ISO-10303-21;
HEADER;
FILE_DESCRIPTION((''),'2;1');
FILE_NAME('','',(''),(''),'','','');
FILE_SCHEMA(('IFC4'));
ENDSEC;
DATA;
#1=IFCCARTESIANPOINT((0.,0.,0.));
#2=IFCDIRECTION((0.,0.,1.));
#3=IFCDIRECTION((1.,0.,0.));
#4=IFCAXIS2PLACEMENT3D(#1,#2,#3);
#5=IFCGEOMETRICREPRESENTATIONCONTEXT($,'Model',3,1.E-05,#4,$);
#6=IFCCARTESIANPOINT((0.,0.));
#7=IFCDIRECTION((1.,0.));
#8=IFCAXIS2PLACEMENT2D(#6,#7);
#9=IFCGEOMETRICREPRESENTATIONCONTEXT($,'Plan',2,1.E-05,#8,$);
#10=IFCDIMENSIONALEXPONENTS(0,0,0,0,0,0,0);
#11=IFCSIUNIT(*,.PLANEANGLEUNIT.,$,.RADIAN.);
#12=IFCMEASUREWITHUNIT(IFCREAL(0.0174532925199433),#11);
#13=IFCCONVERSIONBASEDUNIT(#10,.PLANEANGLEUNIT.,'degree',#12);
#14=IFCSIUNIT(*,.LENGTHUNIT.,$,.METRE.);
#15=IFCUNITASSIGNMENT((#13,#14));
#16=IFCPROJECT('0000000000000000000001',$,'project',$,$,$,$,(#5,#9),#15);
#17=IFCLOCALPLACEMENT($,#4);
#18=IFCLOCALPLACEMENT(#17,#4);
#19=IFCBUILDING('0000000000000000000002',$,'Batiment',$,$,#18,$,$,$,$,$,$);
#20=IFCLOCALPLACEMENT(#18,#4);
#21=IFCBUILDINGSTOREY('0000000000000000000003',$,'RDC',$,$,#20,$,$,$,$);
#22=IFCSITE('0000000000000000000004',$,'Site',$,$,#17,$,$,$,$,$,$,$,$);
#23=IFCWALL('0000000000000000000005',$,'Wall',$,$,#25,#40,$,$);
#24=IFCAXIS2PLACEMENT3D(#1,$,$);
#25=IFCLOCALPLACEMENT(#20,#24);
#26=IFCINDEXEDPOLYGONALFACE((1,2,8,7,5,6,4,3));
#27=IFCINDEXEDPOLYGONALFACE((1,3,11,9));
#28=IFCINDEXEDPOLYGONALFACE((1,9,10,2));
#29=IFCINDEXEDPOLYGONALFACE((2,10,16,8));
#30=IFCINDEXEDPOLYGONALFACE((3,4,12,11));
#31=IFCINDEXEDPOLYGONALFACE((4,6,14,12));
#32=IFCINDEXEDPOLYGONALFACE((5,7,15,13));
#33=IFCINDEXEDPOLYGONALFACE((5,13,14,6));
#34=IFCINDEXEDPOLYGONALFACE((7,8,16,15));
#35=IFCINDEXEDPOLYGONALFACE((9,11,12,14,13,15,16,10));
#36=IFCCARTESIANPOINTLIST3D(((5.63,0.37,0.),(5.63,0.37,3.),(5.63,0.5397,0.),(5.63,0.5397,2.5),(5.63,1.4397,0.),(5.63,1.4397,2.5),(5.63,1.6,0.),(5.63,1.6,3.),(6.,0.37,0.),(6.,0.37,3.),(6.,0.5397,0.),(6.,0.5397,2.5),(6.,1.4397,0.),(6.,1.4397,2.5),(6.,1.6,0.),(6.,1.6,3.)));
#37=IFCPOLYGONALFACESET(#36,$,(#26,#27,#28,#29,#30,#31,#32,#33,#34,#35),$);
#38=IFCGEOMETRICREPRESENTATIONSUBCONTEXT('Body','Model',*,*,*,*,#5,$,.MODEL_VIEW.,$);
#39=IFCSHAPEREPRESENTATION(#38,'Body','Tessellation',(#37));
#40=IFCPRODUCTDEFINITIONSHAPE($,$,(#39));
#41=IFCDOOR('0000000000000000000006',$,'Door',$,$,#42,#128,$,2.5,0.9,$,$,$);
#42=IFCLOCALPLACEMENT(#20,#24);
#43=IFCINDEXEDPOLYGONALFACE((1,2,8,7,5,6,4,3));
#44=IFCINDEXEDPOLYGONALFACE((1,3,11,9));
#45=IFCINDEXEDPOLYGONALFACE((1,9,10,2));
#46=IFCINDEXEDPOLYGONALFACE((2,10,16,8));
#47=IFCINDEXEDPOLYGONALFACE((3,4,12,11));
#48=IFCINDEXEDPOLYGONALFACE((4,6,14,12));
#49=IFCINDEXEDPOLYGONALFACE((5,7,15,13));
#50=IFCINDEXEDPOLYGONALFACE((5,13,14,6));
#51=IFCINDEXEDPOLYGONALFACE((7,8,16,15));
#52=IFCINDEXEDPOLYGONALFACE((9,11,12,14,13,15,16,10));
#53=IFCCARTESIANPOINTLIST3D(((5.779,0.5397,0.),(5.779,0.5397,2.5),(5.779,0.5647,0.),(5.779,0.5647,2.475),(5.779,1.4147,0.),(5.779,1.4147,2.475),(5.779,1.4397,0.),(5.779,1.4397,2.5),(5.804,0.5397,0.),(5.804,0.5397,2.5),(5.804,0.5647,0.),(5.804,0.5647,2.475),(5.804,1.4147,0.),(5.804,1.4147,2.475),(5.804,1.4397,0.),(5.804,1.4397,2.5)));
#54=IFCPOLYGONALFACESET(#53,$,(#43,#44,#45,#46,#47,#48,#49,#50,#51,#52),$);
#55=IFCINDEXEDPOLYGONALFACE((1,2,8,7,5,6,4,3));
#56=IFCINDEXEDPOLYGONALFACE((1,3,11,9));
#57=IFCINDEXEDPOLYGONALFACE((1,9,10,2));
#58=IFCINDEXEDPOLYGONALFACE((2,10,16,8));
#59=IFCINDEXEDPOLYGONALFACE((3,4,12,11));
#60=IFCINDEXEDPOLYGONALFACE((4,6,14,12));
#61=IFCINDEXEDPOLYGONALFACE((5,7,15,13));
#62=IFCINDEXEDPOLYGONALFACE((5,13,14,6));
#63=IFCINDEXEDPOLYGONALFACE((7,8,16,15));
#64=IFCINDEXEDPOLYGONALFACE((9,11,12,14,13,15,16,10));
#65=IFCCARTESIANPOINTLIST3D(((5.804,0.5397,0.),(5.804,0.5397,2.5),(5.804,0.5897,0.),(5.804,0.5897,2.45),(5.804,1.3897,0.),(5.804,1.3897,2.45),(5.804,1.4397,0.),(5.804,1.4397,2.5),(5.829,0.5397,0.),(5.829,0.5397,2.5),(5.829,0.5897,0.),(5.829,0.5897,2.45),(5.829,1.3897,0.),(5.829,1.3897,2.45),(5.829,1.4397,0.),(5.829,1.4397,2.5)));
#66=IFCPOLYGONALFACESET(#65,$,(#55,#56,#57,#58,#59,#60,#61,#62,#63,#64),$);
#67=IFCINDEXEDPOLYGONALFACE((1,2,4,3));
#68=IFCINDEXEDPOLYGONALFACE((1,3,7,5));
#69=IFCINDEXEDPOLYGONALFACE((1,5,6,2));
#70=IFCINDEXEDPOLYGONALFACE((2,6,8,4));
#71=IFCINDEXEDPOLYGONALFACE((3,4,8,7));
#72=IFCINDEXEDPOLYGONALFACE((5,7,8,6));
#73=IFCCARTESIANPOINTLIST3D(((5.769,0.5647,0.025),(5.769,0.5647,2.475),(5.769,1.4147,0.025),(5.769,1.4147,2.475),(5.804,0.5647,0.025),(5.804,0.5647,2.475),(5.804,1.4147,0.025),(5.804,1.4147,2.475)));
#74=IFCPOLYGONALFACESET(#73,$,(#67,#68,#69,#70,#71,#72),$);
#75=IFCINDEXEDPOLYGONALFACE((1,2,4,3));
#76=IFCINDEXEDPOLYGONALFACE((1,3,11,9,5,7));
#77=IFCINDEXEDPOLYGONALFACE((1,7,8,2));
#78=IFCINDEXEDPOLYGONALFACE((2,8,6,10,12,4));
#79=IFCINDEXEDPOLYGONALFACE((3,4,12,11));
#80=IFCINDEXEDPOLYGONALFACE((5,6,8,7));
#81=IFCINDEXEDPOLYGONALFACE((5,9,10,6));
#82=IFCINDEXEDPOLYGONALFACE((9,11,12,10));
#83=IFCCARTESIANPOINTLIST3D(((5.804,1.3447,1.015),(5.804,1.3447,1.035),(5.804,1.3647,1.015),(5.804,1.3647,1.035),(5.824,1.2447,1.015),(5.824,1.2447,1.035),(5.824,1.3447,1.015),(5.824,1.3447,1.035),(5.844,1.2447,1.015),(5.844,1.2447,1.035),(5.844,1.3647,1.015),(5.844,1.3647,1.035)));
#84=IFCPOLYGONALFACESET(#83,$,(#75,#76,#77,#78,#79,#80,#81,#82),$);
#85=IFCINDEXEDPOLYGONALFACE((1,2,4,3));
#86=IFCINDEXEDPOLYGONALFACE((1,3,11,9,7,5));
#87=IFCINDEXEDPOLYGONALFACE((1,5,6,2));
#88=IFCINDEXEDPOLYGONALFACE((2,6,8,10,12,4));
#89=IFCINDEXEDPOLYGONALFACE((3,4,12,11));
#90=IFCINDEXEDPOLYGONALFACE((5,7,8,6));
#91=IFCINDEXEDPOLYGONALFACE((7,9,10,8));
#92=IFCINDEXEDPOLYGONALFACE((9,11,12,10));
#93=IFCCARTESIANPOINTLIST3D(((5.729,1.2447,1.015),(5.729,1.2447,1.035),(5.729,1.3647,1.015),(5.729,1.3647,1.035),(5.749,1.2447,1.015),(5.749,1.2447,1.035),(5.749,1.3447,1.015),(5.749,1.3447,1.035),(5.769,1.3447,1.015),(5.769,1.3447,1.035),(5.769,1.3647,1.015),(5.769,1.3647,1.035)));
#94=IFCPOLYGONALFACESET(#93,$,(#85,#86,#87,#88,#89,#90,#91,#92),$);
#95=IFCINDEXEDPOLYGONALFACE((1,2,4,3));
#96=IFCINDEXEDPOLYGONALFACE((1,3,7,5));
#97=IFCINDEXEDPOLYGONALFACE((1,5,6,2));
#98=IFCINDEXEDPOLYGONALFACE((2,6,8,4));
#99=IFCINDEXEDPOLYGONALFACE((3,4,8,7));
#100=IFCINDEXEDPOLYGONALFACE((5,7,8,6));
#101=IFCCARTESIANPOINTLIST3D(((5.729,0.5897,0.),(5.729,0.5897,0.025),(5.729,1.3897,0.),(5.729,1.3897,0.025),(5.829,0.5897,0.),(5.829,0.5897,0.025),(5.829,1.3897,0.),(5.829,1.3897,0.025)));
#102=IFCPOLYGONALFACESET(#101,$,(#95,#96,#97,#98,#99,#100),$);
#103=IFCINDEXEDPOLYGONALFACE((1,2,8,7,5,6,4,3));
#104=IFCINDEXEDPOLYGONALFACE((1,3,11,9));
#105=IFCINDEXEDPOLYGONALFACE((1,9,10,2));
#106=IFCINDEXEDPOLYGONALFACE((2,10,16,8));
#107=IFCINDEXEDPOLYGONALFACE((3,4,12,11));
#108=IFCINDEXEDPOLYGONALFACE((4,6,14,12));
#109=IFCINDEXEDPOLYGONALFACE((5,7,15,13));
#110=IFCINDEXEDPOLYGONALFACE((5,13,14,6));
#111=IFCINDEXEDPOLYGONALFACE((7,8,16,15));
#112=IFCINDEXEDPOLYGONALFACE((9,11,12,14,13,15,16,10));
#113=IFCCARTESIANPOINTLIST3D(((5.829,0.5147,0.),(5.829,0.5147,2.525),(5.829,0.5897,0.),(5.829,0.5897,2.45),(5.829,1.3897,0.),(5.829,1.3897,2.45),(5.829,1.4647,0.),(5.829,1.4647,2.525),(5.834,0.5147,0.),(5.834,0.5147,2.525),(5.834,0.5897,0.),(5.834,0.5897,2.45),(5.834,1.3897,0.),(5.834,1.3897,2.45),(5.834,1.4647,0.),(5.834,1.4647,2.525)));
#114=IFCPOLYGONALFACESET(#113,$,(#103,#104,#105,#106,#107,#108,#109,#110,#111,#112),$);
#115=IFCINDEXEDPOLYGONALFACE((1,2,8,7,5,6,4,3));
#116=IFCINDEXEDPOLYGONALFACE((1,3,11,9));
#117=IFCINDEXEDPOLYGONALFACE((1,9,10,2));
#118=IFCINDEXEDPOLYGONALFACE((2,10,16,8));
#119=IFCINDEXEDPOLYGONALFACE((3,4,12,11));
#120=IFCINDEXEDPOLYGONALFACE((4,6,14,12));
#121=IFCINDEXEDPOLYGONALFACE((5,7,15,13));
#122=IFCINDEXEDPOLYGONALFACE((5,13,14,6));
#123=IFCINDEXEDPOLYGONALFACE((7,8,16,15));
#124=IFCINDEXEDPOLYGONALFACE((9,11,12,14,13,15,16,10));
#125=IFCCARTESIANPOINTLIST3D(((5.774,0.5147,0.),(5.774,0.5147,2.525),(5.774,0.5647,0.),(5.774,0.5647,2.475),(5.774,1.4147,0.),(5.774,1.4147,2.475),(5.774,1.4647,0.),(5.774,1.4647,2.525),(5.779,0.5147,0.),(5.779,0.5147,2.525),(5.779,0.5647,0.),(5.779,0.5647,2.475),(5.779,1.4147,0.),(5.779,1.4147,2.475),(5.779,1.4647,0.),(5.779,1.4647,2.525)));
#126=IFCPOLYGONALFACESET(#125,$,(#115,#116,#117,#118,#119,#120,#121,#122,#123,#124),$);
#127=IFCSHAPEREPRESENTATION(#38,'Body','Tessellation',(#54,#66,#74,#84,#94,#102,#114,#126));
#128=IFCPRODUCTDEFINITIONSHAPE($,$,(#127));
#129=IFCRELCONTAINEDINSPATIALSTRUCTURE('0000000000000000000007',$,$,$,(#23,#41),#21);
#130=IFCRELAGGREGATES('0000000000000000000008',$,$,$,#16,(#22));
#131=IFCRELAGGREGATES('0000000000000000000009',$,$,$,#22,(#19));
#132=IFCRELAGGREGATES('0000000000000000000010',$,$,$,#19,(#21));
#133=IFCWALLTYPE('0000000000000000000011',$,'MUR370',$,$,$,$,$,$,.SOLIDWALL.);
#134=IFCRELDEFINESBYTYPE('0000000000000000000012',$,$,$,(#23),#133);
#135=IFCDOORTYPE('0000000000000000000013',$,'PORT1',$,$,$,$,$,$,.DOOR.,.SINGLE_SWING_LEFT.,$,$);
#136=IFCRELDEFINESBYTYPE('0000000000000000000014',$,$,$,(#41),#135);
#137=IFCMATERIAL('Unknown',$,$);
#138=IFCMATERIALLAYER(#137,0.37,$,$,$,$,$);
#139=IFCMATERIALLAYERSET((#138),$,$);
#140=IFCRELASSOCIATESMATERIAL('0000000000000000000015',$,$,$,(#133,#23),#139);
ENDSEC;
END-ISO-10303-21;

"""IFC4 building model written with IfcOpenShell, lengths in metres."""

from ifc_helpers import new_model, entity, si_unit, converted_unit, frame, origin_with_axes, origin_2d_with_axis, place, context, subcontext, project, spatial, line, indexed_curve, outline, extrude, shape, source, transform, mapped, material, layer, layer_set, layer_usage, type_object, type_shapes, element, fill, save


model = new_model("IFC4")

# Units and contexts
model_context = context("Model", 3, precision=1e-05, world=origin_with_axes())
plan_context = context("Plan", 2, precision=1e-05, world=origin_2d_with_axis())
body_context_1 = subcontext(model_context, "Body", "Model", "MODEL_VIEW")
body_context_2 = subcontext(plan_context, "Body", "Plan", "PLAN_VIEW")
ifc_project = project(units=[converted_unit("PLANEANGLEUNIT", "degree", entity("IfcReal", 0.0174532925199433), si_unit("PLANEANGLEUNIT", "RADIAN"), dimensions=[0, 0, 0, 0, 0, 0, 0]), si_unit("LENGTHUNIT", "METRE")], contexts=[model_context, plan_context])

# Site, building, storey
site_placement = place(None, origin_with_axes())
site = spatial("IfcSite", under=ifc_project, at=site_placement, Name="Site")
building_placement = place(site_placement, origin_with_axes())
building = spatial("IfcBuilding", under=site, at=building_placement, Name="Batiment")
storey_placement = place(building_placement, origin_with_axes())
storey = spatial("IfcBuildingStorey", under=building, at=storey_placement, Name="RDC")

# Shared definitions
ifc_material = material(Name="Unknown")

# Shared definitions
ifc_layer_1 = layer(ifc_material, 0.37)
ifc_layer_set_1 = layer_set([ifc_layer_1])
wall_type_1 = type_object("IfcWallType", Name="MUR370", PredefinedType="SOLIDWALL", material=ifc_layer_set_1)

# Wall, opening, door
ifc_layer_usage_1 = layer_usage(ifc_layer_set_1, "AXIS2", "POSITIVE", 0.0)
wall_1_placement = place(storey_placement, frame((6.0, 0.37, 0.0), z_axis=(0.0, 0.0, 1.0), x_axis=(0.0, 1.0, 0.0)))
wall_1 = element("IfcWall", 1, at=wall_1_placement, inside=storey, type_object=wall_type_1, material=ifc_layer_usage_1, Name="Wall", context=body_context_1, shape_type="SweptSolid", body=[
    extrude(outline(indexed_curve([(0.0, 0.0), (0.0, 0.37), (1.23, 0.37), (1.23, 0.0), (0.0, 0.0)], self_intersect=False)), origin_with_axes(), (0.0, 0.0, 1.0), 3.0),
])
shared_shape_1 = source(origin_with_axes(), body_context_1, "Body", "SweptSolid", [
    extrude(outline(indexed_curve([(0.0, 0.0), (0.9, 0.0), (0.9, 2.5), (0.0, 2.5)], segments=[line(1, 2, 3, 4, 1)])), frame((0.0, -0.6, 0.0), z_axis=(0.0, -1.0, 0.0), x_axis=(1.0, 0.0, 0.0)), (0.0, 0.0, -1.0), 1.2),
])
opening_1_placement = place(wall_1_placement, frame((0.1697, 0.0, 0.0), z_axis=(0.0, 0.0, 1.0), x_axis=(1.0, 0.0, 0.0)))
opening_1 = element("IfcOpeningElement", 2, at=opening_1_placement, cuts=wall_1, PredefinedType="OPENING", context=body_context_1, shape_type="MappedRepresentation", body=[
    mapped(shared_shape_1, transform((0.0, 0.0, 0.0), x_axis=(1.0, 0.0, 0.0), y_axis=(0.0, 1.0, 0.0), z_axis=(0.0, 0.0, 1.0), scale=1.0)),
])
door_type_1 = type_object("IfcDoorType", Name="PORT1", OperationType="SINGLE_SWING_LEFT", PredefinedType="DOOR")
shared_shape_2 = source(origin_with_axes(), body_context_1, "Body", "SweptSolid", [
    extrude(outline(indexed_curve([(0.0, 0.0), (0.0, 2.5), (0.9, 2.5), (0.9, 0.0), (0.875, 0.0), (0.875, 2.475), (0.025, 2.475), (0.025, 0.0)], segments=[line(1, 2, 3, 4, 5, 6, 7, 8, 1)])), frame((0.0, 0.025, 0.0), z_axis=(0.0, -1.0, 0.0), x_axis=(1.0, 0.0, 0.0)), (0.0, 0.0, -1.0), 0.025),
    extrude(outline(indexed_curve([(0.0, 0.0), (0.0, 2.5), (0.9, 2.5), (0.9, 0.0), (0.85, 0.0), (0.85, 2.45), (0.05, 2.45), (0.05, 0.0)], segments=[line(1, 2, 3, 4, 5, 6, 7, 8, 1)])), frame((0.0, 0.0, 0.0), z_axis=(0.0, -1.0, 0.0), x_axis=(1.0, 0.0, 0.0)), (0.0, 0.0, -1.0), 0.025),
    extrude(outline(indexed_curve([(0.0, 0.0), (0.85, 0.0), (0.85, 0.035), (0.0, 0.035)], segments=[line(1, 2, 3, 4, 1)])), frame((0.025, 0.025, 0.025), z_axis=(0.0, 0.0, 1.0), x_axis=(1.0, 0.0, 0.0)), (0.0, 0.0, 1.0), 2.45),
    extrude(outline(indexed_curve([(0.0, 0.0), (0.0, -0.04), (-0.12, -0.04), (-0.12, -0.02), (-0.02, -0.02), (-0.02, 0.0)], segments=[line(1, 2, 3, 4, 5, 6, 1)])), frame((0.825, 0.025, 1.015), z_axis=(0.0, 0.0, 1.0), x_axis=(1.0, 0.0, 0.0)), (0.0, 0.0, 1.0), 0.02),
    extrude(outline(indexed_curve([(0.0, 0.0), (0.0, 0.04), (-0.12, 0.04), (-0.12, 0.02), (-0.02, 0.02), (-0.02, 0.0)], segments=[line(1, 2, 3, 4, 5, 6, 1)])), frame((0.825, 0.06, 1.015), z_axis=(0.0, 0.0, 1.0), x_axis=(1.0, 0.0, 0.0)), (0.0, 0.0, 1.0), 0.02),
    extrude(outline(indexed_curve([(0.0, 0.0), (0.8, 0.0), (0.8, 0.1), (0.0, 0.1)], segments=[line(1, 2, 3, 4, 1)])), frame((0.05, 0.0, 0.0), z_axis=(0.0, 0.0, 1.0), x_axis=(1.0, 0.0, 0.0)), (0.0, 0.0, 1.0), 0.025),
    extrude(outline(indexed_curve([(0.0, 0.0), (0.0, 2.525), (0.95, 2.525), (0.95, 0.0), (0.875, 0.0), (0.875, 2.45), (0.075, 2.45), (0.075, 0.0)], segments=[line(1, 2, 3, 4, 5, 6, 7, 8, 1)])), frame((-0.025, -0.005, 0.0), z_axis=(0.0, -1.0, 0.0), x_axis=(1.0, 0.0, 0.0)), (0.0, 0.0, -1.0), 0.005),
    extrude(outline(indexed_curve([(0.0, 0.0), (0.0, 2.525), (0.95, 2.525), (0.95, 0.0), (0.9, 0.0), (0.9, 2.475), (0.05, 2.475), (0.05, 0.0)], segments=[line(1, 2, 3, 4, 5, 6, 7, 8, 1)])), frame((-0.025, 0.05, 0.0), z_axis=(0.0, -1.0, 0.0), x_axis=(1.0, 0.0, 0.0)), (0.0, 0.0, -1.0), 0.005),
])
shared_shape_3 = source(origin_with_axes(), body_context_2, "Body", "Curve2D", [
    entity("IfcIndexedPolyCurve", entity("IfcCartesianPointList2D", [[0.0, 0.0], [0.0, 0.05], [0.025, 0.05], [0.025, 0.025], [0.05, 0.025], [0.05, 0.0]]), [entity("IfcLineIndex", [1, 2, 3, 4, 5, 6, 1])]),
    entity("IfcIndexedPolyCurve", entity("IfcCartesianPointList2D", [[0.9, 0.0], [0.9, 0.05], [0.875, 0.05], [0.875, 0.025], [0.85, 0.025], [0.85, 0.0]]), [entity("IfcLineIndex", [1, 2, 3, 4, 5, 6, 1])]),
    entity("IfcTrimmedCurve", entity("IfcEllipse", entity("IfcAxis2Placement2D", entity("IfcCartesianPoint", [0.06, 0.05]), entity("IfcDirection", [1.0, 0.0])), 0.815, 0.85), [entity("IfcCartesianPoint", [0.875, 0.05])], [entity("IfcCartesianPoint", [0.06, 0.9])], True, "CARTESIAN"),
    entity("IfcIndexedPolyCurve", entity("IfcCartesianPointList2D", [[0.025, 0.05], [0.06, 0.05], [0.06, 0.9], [0.025, 0.9]]), [entity("IfcLineIndex", [1, 2, 3, 4, 1])]),
])
type_shapes(door_type_1, [shared_shape_2, shared_shape_3])
door_1_placement = place(opening_1_placement, frame((0.0, 0.171, 0.0), z_axis=(0.0, 0.0, 1.0), x_axis=(1.0, 0.0, 0.0)))
door_1 = element("IfcDoor", 3, at=door_1_placement, inside=storey, type_object=door_type_1, Name="Door", OverallHeight=2.5, OverallWidth=0.9, shapes=[
    shape(body_context_1, "Body", "MappedRepresentation", [mapped(shared_shape_2, transform((0.0, 0.0, 0.0), x_axis=(1.0, 0.0, 0.0), y_axis=(0.0, 1.0, 0.0), z_axis=(0.0, 0.0, 1.0), scale=1.0))]),
    shape(body_context_2, "Body", "MappedRepresentation", [mapped(shared_shape_3, transform((0.0, 0.0, 0.0), x_axis=(1.0, 0.0, 0.0), y_axis=(0.0, 1.0, 0.0), z_axis=(0.0, 0.0, 1.0), scale=1.0))]),
])
fill(opening_1, door_1)

save(model, "model.ifc")
